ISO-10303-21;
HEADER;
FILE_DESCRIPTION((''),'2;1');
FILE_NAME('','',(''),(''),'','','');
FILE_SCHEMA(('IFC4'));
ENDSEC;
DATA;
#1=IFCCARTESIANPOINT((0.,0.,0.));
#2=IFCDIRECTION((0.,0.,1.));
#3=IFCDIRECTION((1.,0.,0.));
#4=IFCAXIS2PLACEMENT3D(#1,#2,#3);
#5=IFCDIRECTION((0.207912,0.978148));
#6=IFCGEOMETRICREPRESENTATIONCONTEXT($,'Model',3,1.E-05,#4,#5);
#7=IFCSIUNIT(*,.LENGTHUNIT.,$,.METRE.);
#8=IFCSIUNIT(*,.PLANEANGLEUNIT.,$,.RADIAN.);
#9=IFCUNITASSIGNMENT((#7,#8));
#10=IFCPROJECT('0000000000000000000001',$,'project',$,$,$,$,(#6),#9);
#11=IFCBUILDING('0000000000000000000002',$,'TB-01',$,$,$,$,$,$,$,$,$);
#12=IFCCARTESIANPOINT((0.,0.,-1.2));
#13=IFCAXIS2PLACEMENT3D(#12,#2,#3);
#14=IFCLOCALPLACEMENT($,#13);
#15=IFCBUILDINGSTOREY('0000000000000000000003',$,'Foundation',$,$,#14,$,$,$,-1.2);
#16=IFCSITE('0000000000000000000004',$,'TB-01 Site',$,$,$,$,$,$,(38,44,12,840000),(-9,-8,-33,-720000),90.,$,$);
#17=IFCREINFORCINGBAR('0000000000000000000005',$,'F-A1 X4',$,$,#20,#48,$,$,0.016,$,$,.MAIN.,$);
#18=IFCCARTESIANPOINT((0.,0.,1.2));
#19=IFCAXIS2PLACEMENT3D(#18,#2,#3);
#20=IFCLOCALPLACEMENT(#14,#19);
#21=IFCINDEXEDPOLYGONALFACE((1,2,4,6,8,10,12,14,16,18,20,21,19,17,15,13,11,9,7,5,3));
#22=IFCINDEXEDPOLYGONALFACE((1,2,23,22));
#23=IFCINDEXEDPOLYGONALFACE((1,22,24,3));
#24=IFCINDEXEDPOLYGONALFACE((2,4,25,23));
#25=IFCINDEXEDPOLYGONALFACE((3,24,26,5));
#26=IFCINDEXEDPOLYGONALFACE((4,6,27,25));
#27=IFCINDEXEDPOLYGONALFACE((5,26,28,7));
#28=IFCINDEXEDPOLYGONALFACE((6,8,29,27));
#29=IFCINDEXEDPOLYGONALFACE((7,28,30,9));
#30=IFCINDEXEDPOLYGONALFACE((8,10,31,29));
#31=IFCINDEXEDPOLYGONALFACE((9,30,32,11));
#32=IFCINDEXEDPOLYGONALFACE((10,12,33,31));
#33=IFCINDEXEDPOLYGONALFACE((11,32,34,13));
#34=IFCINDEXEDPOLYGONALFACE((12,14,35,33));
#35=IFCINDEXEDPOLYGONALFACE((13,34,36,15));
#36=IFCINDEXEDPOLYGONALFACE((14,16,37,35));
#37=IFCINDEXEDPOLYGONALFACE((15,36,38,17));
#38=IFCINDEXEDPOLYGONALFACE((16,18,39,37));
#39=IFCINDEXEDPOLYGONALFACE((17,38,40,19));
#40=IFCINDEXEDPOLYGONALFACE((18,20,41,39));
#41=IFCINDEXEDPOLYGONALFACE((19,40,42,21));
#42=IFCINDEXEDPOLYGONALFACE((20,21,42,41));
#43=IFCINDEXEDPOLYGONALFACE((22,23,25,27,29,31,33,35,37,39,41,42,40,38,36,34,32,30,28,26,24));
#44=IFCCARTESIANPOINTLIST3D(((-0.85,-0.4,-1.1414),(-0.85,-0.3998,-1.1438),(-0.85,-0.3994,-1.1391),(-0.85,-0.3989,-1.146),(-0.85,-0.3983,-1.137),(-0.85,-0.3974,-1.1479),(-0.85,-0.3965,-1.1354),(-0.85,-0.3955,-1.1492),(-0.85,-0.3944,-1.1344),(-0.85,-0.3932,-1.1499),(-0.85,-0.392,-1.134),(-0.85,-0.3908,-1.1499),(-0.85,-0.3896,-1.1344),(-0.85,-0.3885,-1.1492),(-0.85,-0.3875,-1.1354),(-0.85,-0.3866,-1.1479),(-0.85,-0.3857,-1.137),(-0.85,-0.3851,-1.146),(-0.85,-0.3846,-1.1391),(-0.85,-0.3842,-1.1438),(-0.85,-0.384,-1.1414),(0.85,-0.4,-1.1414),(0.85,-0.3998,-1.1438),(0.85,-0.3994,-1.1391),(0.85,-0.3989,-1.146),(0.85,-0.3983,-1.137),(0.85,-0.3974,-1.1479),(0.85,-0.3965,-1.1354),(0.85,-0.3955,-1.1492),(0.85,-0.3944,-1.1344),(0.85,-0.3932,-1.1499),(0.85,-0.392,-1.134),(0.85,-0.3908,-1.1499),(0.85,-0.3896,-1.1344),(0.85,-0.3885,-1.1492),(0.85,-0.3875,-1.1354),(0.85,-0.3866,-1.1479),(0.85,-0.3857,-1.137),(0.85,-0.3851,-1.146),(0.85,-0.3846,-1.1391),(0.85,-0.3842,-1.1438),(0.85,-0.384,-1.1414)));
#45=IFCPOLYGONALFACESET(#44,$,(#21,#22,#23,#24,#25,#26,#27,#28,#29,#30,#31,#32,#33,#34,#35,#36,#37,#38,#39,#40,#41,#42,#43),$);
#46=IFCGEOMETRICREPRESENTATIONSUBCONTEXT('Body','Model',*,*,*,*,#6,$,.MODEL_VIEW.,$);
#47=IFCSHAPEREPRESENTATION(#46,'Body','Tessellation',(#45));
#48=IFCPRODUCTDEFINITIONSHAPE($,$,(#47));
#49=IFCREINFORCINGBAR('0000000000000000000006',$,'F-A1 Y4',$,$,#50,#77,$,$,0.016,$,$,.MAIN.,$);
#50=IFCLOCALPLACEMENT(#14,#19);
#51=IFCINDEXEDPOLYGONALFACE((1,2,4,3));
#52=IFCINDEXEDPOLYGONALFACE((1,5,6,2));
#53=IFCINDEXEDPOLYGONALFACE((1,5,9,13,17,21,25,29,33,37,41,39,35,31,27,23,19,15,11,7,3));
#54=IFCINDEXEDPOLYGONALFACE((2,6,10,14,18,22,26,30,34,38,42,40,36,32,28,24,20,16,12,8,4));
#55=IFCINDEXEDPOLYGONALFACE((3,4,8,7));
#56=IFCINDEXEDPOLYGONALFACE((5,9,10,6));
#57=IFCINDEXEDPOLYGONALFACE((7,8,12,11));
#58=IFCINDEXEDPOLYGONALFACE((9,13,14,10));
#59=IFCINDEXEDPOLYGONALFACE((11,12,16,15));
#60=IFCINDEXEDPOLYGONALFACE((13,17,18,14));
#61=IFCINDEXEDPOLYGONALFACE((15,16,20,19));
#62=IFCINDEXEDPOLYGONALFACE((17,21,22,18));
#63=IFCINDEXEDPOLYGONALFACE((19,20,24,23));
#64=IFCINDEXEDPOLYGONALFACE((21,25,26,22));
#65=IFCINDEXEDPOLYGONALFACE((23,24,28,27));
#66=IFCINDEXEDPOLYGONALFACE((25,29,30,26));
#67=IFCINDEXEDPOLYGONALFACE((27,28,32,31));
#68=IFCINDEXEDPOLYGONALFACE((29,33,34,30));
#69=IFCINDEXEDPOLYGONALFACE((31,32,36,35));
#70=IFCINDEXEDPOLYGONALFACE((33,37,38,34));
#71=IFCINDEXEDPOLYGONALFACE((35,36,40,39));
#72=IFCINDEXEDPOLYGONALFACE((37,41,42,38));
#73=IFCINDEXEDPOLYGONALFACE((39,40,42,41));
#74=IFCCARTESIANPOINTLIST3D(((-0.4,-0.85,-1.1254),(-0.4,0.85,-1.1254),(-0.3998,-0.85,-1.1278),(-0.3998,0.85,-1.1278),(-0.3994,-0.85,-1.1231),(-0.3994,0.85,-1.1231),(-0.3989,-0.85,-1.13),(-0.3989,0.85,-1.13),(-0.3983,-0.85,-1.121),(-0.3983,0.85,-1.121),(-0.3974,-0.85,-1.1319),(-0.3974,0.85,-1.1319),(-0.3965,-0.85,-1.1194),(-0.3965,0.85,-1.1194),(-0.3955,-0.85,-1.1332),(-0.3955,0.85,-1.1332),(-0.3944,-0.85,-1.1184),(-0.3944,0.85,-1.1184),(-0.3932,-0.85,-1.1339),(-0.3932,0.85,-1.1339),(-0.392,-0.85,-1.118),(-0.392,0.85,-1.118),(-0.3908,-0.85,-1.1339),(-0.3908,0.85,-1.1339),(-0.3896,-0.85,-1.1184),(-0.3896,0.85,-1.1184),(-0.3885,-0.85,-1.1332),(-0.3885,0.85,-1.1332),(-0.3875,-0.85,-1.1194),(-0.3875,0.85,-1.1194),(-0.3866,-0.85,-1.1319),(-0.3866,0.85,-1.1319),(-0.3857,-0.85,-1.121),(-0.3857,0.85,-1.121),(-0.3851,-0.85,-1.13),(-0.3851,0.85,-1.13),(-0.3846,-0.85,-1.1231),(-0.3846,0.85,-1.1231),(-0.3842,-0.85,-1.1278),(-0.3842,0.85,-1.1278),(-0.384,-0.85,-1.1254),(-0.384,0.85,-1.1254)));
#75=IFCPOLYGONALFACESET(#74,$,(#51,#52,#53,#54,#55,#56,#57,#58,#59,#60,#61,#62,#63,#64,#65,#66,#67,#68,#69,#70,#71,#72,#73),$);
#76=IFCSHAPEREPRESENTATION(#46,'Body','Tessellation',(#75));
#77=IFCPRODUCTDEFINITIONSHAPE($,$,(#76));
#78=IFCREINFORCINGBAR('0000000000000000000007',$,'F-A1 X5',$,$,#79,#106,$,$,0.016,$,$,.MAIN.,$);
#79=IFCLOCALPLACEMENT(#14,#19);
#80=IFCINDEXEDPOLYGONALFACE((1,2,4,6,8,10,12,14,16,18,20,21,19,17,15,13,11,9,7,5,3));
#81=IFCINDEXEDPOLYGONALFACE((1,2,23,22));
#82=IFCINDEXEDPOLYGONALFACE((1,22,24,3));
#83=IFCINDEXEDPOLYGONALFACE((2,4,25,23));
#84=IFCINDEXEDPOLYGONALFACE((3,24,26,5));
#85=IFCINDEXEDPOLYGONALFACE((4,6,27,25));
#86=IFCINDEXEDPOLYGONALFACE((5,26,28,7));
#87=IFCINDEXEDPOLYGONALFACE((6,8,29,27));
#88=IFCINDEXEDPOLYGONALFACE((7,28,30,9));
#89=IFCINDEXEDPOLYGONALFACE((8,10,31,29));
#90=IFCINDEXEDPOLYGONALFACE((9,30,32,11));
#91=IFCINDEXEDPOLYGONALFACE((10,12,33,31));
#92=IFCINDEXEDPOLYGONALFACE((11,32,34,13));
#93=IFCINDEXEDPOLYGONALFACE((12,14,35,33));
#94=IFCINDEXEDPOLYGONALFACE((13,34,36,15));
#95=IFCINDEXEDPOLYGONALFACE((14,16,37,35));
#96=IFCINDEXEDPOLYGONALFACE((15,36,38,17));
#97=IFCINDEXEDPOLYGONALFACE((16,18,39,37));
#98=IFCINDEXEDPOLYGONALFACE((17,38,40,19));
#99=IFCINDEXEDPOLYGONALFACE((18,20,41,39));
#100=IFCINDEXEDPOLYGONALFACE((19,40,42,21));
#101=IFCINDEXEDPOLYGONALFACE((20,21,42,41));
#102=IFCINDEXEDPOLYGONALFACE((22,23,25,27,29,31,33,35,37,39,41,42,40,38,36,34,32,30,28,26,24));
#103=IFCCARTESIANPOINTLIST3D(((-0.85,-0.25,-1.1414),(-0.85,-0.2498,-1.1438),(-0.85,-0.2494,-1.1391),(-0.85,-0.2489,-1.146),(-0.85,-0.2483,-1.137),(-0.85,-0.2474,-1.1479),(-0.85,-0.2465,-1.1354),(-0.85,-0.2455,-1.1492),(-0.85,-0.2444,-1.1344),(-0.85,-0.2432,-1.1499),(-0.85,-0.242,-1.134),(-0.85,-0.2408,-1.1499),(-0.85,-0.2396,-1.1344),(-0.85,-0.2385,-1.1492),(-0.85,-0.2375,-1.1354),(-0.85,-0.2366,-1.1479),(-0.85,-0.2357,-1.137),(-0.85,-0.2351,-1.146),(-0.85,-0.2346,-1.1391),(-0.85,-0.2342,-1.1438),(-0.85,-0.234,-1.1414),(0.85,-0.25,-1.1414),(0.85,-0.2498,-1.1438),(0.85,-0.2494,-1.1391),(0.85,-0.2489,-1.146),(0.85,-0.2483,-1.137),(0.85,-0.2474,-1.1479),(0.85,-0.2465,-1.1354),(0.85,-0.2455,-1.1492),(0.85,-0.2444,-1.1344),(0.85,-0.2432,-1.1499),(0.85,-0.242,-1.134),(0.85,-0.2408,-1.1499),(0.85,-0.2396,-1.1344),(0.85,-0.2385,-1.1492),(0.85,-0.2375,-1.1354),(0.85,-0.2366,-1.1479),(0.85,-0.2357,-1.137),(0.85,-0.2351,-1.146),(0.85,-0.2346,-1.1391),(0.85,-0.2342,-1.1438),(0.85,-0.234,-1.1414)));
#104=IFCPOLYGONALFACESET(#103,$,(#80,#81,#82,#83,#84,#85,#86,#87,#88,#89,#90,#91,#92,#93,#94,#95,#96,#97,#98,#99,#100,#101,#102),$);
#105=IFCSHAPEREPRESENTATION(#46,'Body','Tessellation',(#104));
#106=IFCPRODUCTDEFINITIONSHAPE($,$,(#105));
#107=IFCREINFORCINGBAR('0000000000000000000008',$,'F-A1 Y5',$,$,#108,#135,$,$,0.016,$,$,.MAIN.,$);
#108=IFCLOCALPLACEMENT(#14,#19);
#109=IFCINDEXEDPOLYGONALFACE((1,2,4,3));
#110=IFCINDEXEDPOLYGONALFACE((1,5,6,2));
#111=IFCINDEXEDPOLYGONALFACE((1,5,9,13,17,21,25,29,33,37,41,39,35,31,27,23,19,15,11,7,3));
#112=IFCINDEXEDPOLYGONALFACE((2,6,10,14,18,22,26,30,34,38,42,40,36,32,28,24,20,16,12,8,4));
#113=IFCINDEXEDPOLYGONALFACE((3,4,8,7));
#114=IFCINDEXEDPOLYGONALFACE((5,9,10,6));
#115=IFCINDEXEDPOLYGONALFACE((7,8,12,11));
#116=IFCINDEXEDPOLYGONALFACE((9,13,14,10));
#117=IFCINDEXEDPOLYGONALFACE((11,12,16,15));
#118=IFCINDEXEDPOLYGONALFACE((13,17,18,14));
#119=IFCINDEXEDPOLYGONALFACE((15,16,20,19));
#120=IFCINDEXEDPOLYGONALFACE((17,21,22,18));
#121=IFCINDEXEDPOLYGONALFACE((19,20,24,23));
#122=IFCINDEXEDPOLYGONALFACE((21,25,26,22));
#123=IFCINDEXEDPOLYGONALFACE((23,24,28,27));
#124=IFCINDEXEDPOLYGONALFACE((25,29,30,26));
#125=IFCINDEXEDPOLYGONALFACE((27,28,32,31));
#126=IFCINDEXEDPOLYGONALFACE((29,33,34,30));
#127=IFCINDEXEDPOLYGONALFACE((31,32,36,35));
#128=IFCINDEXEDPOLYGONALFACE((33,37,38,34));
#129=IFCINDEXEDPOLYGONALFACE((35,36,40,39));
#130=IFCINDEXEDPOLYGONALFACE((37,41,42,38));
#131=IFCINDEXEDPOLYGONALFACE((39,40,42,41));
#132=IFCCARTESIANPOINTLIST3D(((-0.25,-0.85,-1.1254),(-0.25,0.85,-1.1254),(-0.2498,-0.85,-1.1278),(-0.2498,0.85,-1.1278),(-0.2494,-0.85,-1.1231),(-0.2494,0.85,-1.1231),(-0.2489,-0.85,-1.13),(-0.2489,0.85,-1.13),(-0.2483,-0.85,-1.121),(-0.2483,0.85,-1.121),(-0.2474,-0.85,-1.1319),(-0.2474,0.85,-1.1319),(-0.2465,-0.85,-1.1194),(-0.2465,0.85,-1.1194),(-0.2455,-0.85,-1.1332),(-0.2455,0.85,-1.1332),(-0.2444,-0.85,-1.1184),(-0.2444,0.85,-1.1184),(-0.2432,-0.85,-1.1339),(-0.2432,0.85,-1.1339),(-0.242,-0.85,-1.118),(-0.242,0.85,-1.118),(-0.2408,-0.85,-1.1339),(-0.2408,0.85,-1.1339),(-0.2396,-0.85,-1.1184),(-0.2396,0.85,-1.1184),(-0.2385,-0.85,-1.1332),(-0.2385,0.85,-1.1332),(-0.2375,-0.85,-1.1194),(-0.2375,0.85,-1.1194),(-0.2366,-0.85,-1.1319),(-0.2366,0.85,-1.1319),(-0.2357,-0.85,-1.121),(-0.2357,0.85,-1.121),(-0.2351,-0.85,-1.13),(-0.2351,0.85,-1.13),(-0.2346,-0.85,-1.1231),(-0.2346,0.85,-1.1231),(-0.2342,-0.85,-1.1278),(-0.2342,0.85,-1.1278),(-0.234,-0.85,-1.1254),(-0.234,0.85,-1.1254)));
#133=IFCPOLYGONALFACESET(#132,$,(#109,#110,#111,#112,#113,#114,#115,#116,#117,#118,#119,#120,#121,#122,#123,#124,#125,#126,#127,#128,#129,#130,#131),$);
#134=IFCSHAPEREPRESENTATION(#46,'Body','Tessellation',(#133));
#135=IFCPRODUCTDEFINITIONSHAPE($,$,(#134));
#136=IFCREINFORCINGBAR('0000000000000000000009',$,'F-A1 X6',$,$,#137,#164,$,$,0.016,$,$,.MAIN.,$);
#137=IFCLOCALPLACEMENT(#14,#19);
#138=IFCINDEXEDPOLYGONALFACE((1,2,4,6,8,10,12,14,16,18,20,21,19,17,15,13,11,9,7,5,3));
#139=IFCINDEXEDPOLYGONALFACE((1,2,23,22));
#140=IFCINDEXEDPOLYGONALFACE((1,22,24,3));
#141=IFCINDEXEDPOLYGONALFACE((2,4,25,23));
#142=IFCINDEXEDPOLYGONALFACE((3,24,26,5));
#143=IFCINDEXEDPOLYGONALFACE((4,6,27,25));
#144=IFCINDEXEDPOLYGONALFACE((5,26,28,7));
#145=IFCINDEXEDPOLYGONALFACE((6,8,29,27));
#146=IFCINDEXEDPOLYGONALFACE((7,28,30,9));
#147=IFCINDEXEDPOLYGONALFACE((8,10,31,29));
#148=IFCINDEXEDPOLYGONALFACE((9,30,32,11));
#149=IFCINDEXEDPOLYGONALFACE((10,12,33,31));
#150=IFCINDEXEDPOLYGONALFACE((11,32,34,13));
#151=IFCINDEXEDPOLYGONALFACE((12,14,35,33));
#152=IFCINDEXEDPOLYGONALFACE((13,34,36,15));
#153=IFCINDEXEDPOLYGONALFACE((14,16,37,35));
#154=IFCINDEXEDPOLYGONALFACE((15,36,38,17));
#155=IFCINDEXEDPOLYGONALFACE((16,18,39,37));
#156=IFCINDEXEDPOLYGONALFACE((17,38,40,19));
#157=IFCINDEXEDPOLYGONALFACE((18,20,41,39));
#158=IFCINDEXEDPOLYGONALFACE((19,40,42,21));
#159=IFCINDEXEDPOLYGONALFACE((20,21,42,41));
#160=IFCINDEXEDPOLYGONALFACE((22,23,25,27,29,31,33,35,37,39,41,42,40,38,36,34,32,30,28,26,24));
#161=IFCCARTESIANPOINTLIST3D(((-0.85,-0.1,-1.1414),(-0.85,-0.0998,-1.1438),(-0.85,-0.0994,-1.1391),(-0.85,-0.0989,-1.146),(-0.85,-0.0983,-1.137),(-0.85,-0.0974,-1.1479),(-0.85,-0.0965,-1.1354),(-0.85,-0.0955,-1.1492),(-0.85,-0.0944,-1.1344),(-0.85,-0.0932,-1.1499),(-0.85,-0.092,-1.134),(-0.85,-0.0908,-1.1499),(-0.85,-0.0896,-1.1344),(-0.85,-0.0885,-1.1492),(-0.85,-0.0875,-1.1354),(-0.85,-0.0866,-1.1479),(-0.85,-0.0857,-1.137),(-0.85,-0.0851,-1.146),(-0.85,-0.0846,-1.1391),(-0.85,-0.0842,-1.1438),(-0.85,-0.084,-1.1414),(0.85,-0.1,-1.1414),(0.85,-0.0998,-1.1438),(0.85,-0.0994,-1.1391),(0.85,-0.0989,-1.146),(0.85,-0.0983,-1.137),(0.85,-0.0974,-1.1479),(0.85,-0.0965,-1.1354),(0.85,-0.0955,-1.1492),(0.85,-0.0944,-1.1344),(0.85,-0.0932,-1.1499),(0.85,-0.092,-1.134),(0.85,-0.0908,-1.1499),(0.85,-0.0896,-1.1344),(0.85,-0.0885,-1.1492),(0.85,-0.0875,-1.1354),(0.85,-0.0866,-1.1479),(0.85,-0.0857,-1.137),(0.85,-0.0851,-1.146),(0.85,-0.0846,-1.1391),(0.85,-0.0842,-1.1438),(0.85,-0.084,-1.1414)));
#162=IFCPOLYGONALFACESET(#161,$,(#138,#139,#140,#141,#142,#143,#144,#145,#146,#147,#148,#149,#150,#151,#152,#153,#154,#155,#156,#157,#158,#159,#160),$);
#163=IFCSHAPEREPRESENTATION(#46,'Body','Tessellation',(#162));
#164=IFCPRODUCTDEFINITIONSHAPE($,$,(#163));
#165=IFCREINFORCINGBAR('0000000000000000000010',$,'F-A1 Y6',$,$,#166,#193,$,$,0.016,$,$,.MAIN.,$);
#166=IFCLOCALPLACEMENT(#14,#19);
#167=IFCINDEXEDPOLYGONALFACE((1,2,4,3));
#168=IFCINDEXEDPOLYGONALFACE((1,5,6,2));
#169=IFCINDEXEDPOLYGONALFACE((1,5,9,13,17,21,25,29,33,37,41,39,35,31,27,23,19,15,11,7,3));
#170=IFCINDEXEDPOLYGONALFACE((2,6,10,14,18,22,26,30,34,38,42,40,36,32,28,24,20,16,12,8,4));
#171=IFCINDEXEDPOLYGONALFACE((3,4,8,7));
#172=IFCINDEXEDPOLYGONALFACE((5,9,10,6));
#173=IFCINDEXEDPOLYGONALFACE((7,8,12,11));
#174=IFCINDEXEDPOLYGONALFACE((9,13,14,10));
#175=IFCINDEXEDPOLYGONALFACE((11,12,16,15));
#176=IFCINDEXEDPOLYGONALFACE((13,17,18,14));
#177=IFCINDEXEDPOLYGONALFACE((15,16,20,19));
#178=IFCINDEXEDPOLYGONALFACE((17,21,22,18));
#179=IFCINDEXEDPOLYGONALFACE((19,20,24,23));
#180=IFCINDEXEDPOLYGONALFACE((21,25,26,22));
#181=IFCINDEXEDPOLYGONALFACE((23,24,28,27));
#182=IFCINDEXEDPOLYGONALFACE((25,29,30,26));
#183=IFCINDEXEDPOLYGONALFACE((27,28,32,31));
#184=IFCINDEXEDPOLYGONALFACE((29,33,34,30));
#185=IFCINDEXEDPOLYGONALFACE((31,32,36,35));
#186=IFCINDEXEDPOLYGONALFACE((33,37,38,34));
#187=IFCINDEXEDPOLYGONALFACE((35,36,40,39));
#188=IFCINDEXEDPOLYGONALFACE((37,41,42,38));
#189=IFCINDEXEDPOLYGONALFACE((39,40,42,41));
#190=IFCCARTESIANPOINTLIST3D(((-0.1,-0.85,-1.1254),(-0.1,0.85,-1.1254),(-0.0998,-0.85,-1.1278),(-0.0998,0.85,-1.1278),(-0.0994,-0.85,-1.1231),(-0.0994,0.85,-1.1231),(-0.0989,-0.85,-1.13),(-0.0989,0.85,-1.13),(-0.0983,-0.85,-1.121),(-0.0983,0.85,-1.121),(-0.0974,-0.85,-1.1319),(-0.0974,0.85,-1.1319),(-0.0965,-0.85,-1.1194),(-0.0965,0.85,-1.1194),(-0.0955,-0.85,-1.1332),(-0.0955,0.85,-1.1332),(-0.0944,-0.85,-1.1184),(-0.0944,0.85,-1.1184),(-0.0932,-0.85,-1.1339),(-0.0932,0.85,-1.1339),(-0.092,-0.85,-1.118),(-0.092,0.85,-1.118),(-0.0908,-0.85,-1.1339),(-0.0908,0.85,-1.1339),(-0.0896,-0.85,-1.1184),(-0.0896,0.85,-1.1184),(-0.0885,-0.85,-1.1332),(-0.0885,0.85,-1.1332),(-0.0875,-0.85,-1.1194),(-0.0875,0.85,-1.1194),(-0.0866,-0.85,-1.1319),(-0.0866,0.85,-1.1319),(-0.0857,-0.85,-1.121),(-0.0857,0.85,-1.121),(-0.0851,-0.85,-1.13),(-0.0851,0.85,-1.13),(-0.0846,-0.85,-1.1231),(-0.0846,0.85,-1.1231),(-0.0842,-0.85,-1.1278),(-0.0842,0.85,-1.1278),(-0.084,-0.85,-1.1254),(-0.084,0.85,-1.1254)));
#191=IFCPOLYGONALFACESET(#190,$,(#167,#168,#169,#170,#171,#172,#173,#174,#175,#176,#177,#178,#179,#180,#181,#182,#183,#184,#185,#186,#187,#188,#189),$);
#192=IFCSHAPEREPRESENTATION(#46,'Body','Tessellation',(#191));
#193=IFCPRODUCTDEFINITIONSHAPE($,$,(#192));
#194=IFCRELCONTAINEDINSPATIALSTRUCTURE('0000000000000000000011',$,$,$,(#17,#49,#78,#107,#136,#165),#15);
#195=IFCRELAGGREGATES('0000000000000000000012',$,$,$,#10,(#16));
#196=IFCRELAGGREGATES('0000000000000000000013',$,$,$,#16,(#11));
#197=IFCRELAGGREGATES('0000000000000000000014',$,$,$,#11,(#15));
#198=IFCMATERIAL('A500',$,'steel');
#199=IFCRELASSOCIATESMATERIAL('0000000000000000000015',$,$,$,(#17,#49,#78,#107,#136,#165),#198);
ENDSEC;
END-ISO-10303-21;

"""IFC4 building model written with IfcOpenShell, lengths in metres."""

from ifc_helpers import new_model, entity, si_unit, direction, frame, origin_with_axes, place, context, subcontext, project, spatial, material, element, save


model = new_model("IFC4")

# Units and contexts
model_context = context("Model", 3, precision=1e-05, world=origin_with_axes(), true_north=direction((0.207912, 0.978148)))
body_context = subcontext(model_context, "Body", "Model", "MODEL_VIEW")
ifc_project = project(units=[si_unit("LENGTHUNIT", "METRE"), si_unit("PLANEANGLEUNIT", "RADIAN")], contexts=[model_context])

# Site, building, storey
site = spatial("IfcSite", under=ifc_project, Name="TB-01 Site", RefLatitude=(38, 44, 12, 840000), RefLongitude=(-9, -8, -33, -720000), RefElevation=90.0)
building = spatial("IfcBuilding", under=site, Name="TB-01")
storey_placement = place(None, frame((0.0, 0.0, -1.2), z_axis=(0.0, 0.0, 1.0), x_axis=(1.0, 0.0, 0.0)))
storey = spatial("IfcBuildingStorey", under=building, at=storey_placement, Name="Foundation", Elevation=-1.2)

# Reinforcing bars
ifc_material_1 = material(Name="A500", Category="steel")
reinforcing_bar_1_placement = place(storey_placement, frame((0.0, 0.0, 1.2), z_axis=(0.0, 0.0, 1.0), x_axis=(1.0, 0.0, 0.0)))
element("IfcReinforcingBar", 1, at=reinforcing_bar_1_placement, inside=storey, material=ifc_material_1, Name="F-A1 X4", NominalDiameter=0.016, PredefinedType="MAIN", context=body_context, shape_type="AdvancedSweptSolid", body=[
    entity("IfcSweptDiskSolid", entity("IfcPolyline", [entity("IfcCartesianPoint", [-0.85, -0.392, -1.142]), entity("IfcCartesianPoint", [0.85, -0.392, -1.142])]), 0.008),
])
reinforcing_bar_2_placement = place(storey_placement, frame((0.0, 0.0, 1.2), z_axis=(0.0, 0.0, 1.0), x_axis=(1.0, 0.0, 0.0)))
element("IfcReinforcingBar", 2, at=reinforcing_bar_2_placement, inside=storey, material=ifc_material_1, Name="F-A1 Y4", NominalDiameter=0.016, PredefinedType="MAIN", context=body_context, shape_type="AdvancedSweptSolid", body=[
    entity("IfcSweptDiskSolid", entity("IfcPolyline", [entity("IfcCartesianPoint", [-0.392, -0.85, -1.126]), entity("IfcCartesianPoint", [-0.392, 0.85, -1.126])]), 0.008),
])
reinforcing_bar_3_placement = place(storey_placement, frame((0.0, 0.0, 1.2), z_axis=(0.0, 0.0, 1.0), x_axis=(1.0, 0.0, 0.0)))
element("IfcReinforcingBar", 3, at=reinforcing_bar_3_placement, inside=storey, material=ifc_material_1, Name="F-A1 X5", NominalDiameter=0.016, PredefinedType="MAIN", context=body_context, shape_type="AdvancedSweptSolid", body=[
    entity("IfcSweptDiskSolid", entity("IfcPolyline", [entity("IfcCartesianPoint", [-0.85, -0.242, -1.142]), entity("IfcCartesianPoint", [0.85, -0.242, -1.142])]), 0.008),
])
reinforcing_bar_4_placement = place(storey_placement, frame((0.0, 0.0, 1.2), z_axis=(0.0, 0.0, 1.0), x_axis=(1.0, 0.0, 0.0)))
element("IfcReinforcingBar", 4, at=reinforcing_bar_4_placement, inside=storey, material=ifc_material_1, Name="F-A1 Y5", NominalDiameter=0.016, PredefinedType="MAIN", context=body_context, shape_type="AdvancedSweptSolid", body=[
    entity("IfcSweptDiskSolid", entity("IfcPolyline", [entity("IfcCartesianPoint", [-0.242, -0.85, -1.126]), entity("IfcCartesianPoint", [-0.242, 0.85, -1.126])]), 0.008),
])
reinforcing_bar_5_placement = place(storey_placement, frame((0.0, 0.0, 1.2), z_axis=(0.0, 0.0, 1.0), x_axis=(1.0, 0.0, 0.0)))
element("IfcReinforcingBar", 5, at=reinforcing_bar_5_placement, inside=storey, material=ifc_material_1, Name="F-A1 X6", NominalDiameter=0.016, PredefinedType="MAIN", context=body_context, shape_type="AdvancedSweptSolid", body=[
    entity("IfcSweptDiskSolid", entity("IfcPolyline", [entity("IfcCartesianPoint", [-0.85, -0.092, -1.142]), entity("IfcCartesianPoint", [0.85, -0.092, -1.142])]), 0.008),
])
reinforcing_bar_6_placement = place(storey_placement, frame((0.0, 0.0, 1.2), z_axis=(0.0, 0.0, 1.0), x_axis=(1.0, 0.0, 0.0)))
element("IfcReinforcingBar", 6, at=reinforcing_bar_6_placement, inside=storey, material=ifc_material_1, Name="F-A1 Y6", NominalDiameter=0.016, PredefinedType="MAIN", context=body_context, shape_type="AdvancedSweptSolid", body=[
    entity("IfcSweptDiskSolid", entity("IfcPolyline", [entity("IfcCartesianPoint", [-0.092, -0.85, -1.126]), entity("IfcCartesianPoint", [-0.092, 0.85, -1.126])]), 0.008),
])

save(model, "model.ifc")
